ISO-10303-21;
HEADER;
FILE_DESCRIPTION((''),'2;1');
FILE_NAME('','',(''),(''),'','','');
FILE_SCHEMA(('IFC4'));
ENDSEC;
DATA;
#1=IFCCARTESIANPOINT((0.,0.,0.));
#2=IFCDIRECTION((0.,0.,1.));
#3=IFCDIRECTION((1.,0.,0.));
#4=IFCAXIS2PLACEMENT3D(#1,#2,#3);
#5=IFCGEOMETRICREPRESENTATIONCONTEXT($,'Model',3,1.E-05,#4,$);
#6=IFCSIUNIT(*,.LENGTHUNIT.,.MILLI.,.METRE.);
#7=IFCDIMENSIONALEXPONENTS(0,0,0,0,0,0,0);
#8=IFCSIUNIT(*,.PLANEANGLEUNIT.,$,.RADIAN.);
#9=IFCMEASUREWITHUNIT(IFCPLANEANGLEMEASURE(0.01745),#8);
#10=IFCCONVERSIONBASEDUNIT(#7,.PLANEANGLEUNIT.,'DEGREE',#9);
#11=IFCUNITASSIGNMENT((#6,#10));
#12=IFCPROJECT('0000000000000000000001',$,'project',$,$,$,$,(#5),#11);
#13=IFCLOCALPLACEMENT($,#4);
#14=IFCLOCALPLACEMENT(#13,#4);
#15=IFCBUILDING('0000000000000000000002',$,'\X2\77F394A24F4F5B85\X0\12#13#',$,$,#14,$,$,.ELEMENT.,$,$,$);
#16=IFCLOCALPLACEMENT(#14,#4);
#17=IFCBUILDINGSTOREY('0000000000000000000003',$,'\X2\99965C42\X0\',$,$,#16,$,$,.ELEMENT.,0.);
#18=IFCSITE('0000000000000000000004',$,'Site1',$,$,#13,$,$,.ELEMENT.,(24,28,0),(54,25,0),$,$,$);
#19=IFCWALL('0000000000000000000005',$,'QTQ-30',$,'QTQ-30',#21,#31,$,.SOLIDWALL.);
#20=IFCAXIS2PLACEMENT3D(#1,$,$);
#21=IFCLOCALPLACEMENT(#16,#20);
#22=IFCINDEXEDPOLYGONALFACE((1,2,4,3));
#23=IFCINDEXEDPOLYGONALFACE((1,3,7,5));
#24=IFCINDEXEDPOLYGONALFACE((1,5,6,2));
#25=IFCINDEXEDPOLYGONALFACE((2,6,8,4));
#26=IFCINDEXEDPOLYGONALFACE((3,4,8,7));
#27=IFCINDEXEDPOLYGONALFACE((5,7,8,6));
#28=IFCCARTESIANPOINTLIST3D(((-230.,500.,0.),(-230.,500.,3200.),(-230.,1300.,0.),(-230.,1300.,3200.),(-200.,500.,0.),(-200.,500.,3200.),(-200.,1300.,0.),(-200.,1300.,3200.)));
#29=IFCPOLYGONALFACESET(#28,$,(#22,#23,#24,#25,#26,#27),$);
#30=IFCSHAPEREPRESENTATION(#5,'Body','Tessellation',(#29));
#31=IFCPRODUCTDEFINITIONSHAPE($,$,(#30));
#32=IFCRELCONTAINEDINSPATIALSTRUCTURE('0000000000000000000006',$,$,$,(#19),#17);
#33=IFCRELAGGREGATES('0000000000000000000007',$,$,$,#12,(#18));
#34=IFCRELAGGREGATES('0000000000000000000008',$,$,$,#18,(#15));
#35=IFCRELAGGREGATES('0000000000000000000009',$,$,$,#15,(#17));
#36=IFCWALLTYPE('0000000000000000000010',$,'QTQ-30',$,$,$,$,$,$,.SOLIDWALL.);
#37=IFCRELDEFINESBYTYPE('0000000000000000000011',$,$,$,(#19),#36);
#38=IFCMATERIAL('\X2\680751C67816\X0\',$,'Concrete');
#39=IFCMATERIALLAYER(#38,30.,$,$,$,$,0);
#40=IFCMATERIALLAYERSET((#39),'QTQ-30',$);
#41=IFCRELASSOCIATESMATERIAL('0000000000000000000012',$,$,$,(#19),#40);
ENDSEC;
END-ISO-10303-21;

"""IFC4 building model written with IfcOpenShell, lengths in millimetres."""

from ifc_helpers import new_model, entity, si_unit, converted_unit, frame, origin_with_axes, place, context, project, spatial, polyline, outline, extrude, material, layer, layer_set, type_object, element, save


model = new_model("IFC4")

# Units and contexts
model_context = context("Model", 3, precision=1e-05, world=origin_with_axes())
ifc_project = project(units=[si_unit("LENGTHUNIT", "METRE", prefix="MILLI"), converted_unit("PLANEANGLEUNIT", "DEGREE", entity("IfcPlaneAngleMeasure", 0.01745), si_unit("PLANEANGLEUNIT", "RADIAN"), dimensions=[0, 0, 0, 0, 0, 0, 0])], contexts=[model_context])

# Site, building, storey
site_placement = place(None, origin_with_axes())
site = spatial("IfcSite", under=ifc_project, at=site_placement, Name="Site1", CompositionType="ELEMENT", RefLatitude=(24, 28, 0), RefLongitude=(54, 25, 0))
building_placement = place(site_placement, origin_with_axes())
building = spatial("IfcBuilding", under=site, at=building_placement, Name="石钢住宅12#13#", CompositionType="ELEMENT")
storey_placement = place(building_placement, origin_with_axes())
storey = spatial("IfcBuildingStorey", under=building, at=storey_placement, Name="首层", CompositionType="ELEMENT", Elevation=0.0)

# Wall
ifc_material_1 = material(Name="标准砖", Category="Concrete")
ifc_layer = layer(ifc_material_1, 30.0, Priority=0)
ifc_layer_set = layer_set([ifc_layer], Name="QTQ-30")
wall_type = type_object("IfcWallType", Name="QTQ-30", PredefinedType="SOLIDWALL")
wall_1_placement = place(storey_placement, origin_with_axes())
element("IfcWall", 1, at=wall_1_placement, inside=storey, type_object=wall_type, material=ifc_layer_set, Name="QTQ-30", ObjectType="QTQ-30", PredefinedType="SOLIDWALL", context=model_context, shape_type="SweptSolid", body=[
    extrude(outline(polyline([(0.0, 0.0), (3200.0, 0.0), (3200.0, 800.0), (0.0, 800.0), (0.0, 0.0)])), frame((-200.0, 1300.0, 3200.0), z_axis=(-1.0, 0.0, 0.0), x_axis=(0.0, 0.0, -1.0)), (0.0, 0.0, 1.0), 30.0),
])

save(model, "model.ifc")
